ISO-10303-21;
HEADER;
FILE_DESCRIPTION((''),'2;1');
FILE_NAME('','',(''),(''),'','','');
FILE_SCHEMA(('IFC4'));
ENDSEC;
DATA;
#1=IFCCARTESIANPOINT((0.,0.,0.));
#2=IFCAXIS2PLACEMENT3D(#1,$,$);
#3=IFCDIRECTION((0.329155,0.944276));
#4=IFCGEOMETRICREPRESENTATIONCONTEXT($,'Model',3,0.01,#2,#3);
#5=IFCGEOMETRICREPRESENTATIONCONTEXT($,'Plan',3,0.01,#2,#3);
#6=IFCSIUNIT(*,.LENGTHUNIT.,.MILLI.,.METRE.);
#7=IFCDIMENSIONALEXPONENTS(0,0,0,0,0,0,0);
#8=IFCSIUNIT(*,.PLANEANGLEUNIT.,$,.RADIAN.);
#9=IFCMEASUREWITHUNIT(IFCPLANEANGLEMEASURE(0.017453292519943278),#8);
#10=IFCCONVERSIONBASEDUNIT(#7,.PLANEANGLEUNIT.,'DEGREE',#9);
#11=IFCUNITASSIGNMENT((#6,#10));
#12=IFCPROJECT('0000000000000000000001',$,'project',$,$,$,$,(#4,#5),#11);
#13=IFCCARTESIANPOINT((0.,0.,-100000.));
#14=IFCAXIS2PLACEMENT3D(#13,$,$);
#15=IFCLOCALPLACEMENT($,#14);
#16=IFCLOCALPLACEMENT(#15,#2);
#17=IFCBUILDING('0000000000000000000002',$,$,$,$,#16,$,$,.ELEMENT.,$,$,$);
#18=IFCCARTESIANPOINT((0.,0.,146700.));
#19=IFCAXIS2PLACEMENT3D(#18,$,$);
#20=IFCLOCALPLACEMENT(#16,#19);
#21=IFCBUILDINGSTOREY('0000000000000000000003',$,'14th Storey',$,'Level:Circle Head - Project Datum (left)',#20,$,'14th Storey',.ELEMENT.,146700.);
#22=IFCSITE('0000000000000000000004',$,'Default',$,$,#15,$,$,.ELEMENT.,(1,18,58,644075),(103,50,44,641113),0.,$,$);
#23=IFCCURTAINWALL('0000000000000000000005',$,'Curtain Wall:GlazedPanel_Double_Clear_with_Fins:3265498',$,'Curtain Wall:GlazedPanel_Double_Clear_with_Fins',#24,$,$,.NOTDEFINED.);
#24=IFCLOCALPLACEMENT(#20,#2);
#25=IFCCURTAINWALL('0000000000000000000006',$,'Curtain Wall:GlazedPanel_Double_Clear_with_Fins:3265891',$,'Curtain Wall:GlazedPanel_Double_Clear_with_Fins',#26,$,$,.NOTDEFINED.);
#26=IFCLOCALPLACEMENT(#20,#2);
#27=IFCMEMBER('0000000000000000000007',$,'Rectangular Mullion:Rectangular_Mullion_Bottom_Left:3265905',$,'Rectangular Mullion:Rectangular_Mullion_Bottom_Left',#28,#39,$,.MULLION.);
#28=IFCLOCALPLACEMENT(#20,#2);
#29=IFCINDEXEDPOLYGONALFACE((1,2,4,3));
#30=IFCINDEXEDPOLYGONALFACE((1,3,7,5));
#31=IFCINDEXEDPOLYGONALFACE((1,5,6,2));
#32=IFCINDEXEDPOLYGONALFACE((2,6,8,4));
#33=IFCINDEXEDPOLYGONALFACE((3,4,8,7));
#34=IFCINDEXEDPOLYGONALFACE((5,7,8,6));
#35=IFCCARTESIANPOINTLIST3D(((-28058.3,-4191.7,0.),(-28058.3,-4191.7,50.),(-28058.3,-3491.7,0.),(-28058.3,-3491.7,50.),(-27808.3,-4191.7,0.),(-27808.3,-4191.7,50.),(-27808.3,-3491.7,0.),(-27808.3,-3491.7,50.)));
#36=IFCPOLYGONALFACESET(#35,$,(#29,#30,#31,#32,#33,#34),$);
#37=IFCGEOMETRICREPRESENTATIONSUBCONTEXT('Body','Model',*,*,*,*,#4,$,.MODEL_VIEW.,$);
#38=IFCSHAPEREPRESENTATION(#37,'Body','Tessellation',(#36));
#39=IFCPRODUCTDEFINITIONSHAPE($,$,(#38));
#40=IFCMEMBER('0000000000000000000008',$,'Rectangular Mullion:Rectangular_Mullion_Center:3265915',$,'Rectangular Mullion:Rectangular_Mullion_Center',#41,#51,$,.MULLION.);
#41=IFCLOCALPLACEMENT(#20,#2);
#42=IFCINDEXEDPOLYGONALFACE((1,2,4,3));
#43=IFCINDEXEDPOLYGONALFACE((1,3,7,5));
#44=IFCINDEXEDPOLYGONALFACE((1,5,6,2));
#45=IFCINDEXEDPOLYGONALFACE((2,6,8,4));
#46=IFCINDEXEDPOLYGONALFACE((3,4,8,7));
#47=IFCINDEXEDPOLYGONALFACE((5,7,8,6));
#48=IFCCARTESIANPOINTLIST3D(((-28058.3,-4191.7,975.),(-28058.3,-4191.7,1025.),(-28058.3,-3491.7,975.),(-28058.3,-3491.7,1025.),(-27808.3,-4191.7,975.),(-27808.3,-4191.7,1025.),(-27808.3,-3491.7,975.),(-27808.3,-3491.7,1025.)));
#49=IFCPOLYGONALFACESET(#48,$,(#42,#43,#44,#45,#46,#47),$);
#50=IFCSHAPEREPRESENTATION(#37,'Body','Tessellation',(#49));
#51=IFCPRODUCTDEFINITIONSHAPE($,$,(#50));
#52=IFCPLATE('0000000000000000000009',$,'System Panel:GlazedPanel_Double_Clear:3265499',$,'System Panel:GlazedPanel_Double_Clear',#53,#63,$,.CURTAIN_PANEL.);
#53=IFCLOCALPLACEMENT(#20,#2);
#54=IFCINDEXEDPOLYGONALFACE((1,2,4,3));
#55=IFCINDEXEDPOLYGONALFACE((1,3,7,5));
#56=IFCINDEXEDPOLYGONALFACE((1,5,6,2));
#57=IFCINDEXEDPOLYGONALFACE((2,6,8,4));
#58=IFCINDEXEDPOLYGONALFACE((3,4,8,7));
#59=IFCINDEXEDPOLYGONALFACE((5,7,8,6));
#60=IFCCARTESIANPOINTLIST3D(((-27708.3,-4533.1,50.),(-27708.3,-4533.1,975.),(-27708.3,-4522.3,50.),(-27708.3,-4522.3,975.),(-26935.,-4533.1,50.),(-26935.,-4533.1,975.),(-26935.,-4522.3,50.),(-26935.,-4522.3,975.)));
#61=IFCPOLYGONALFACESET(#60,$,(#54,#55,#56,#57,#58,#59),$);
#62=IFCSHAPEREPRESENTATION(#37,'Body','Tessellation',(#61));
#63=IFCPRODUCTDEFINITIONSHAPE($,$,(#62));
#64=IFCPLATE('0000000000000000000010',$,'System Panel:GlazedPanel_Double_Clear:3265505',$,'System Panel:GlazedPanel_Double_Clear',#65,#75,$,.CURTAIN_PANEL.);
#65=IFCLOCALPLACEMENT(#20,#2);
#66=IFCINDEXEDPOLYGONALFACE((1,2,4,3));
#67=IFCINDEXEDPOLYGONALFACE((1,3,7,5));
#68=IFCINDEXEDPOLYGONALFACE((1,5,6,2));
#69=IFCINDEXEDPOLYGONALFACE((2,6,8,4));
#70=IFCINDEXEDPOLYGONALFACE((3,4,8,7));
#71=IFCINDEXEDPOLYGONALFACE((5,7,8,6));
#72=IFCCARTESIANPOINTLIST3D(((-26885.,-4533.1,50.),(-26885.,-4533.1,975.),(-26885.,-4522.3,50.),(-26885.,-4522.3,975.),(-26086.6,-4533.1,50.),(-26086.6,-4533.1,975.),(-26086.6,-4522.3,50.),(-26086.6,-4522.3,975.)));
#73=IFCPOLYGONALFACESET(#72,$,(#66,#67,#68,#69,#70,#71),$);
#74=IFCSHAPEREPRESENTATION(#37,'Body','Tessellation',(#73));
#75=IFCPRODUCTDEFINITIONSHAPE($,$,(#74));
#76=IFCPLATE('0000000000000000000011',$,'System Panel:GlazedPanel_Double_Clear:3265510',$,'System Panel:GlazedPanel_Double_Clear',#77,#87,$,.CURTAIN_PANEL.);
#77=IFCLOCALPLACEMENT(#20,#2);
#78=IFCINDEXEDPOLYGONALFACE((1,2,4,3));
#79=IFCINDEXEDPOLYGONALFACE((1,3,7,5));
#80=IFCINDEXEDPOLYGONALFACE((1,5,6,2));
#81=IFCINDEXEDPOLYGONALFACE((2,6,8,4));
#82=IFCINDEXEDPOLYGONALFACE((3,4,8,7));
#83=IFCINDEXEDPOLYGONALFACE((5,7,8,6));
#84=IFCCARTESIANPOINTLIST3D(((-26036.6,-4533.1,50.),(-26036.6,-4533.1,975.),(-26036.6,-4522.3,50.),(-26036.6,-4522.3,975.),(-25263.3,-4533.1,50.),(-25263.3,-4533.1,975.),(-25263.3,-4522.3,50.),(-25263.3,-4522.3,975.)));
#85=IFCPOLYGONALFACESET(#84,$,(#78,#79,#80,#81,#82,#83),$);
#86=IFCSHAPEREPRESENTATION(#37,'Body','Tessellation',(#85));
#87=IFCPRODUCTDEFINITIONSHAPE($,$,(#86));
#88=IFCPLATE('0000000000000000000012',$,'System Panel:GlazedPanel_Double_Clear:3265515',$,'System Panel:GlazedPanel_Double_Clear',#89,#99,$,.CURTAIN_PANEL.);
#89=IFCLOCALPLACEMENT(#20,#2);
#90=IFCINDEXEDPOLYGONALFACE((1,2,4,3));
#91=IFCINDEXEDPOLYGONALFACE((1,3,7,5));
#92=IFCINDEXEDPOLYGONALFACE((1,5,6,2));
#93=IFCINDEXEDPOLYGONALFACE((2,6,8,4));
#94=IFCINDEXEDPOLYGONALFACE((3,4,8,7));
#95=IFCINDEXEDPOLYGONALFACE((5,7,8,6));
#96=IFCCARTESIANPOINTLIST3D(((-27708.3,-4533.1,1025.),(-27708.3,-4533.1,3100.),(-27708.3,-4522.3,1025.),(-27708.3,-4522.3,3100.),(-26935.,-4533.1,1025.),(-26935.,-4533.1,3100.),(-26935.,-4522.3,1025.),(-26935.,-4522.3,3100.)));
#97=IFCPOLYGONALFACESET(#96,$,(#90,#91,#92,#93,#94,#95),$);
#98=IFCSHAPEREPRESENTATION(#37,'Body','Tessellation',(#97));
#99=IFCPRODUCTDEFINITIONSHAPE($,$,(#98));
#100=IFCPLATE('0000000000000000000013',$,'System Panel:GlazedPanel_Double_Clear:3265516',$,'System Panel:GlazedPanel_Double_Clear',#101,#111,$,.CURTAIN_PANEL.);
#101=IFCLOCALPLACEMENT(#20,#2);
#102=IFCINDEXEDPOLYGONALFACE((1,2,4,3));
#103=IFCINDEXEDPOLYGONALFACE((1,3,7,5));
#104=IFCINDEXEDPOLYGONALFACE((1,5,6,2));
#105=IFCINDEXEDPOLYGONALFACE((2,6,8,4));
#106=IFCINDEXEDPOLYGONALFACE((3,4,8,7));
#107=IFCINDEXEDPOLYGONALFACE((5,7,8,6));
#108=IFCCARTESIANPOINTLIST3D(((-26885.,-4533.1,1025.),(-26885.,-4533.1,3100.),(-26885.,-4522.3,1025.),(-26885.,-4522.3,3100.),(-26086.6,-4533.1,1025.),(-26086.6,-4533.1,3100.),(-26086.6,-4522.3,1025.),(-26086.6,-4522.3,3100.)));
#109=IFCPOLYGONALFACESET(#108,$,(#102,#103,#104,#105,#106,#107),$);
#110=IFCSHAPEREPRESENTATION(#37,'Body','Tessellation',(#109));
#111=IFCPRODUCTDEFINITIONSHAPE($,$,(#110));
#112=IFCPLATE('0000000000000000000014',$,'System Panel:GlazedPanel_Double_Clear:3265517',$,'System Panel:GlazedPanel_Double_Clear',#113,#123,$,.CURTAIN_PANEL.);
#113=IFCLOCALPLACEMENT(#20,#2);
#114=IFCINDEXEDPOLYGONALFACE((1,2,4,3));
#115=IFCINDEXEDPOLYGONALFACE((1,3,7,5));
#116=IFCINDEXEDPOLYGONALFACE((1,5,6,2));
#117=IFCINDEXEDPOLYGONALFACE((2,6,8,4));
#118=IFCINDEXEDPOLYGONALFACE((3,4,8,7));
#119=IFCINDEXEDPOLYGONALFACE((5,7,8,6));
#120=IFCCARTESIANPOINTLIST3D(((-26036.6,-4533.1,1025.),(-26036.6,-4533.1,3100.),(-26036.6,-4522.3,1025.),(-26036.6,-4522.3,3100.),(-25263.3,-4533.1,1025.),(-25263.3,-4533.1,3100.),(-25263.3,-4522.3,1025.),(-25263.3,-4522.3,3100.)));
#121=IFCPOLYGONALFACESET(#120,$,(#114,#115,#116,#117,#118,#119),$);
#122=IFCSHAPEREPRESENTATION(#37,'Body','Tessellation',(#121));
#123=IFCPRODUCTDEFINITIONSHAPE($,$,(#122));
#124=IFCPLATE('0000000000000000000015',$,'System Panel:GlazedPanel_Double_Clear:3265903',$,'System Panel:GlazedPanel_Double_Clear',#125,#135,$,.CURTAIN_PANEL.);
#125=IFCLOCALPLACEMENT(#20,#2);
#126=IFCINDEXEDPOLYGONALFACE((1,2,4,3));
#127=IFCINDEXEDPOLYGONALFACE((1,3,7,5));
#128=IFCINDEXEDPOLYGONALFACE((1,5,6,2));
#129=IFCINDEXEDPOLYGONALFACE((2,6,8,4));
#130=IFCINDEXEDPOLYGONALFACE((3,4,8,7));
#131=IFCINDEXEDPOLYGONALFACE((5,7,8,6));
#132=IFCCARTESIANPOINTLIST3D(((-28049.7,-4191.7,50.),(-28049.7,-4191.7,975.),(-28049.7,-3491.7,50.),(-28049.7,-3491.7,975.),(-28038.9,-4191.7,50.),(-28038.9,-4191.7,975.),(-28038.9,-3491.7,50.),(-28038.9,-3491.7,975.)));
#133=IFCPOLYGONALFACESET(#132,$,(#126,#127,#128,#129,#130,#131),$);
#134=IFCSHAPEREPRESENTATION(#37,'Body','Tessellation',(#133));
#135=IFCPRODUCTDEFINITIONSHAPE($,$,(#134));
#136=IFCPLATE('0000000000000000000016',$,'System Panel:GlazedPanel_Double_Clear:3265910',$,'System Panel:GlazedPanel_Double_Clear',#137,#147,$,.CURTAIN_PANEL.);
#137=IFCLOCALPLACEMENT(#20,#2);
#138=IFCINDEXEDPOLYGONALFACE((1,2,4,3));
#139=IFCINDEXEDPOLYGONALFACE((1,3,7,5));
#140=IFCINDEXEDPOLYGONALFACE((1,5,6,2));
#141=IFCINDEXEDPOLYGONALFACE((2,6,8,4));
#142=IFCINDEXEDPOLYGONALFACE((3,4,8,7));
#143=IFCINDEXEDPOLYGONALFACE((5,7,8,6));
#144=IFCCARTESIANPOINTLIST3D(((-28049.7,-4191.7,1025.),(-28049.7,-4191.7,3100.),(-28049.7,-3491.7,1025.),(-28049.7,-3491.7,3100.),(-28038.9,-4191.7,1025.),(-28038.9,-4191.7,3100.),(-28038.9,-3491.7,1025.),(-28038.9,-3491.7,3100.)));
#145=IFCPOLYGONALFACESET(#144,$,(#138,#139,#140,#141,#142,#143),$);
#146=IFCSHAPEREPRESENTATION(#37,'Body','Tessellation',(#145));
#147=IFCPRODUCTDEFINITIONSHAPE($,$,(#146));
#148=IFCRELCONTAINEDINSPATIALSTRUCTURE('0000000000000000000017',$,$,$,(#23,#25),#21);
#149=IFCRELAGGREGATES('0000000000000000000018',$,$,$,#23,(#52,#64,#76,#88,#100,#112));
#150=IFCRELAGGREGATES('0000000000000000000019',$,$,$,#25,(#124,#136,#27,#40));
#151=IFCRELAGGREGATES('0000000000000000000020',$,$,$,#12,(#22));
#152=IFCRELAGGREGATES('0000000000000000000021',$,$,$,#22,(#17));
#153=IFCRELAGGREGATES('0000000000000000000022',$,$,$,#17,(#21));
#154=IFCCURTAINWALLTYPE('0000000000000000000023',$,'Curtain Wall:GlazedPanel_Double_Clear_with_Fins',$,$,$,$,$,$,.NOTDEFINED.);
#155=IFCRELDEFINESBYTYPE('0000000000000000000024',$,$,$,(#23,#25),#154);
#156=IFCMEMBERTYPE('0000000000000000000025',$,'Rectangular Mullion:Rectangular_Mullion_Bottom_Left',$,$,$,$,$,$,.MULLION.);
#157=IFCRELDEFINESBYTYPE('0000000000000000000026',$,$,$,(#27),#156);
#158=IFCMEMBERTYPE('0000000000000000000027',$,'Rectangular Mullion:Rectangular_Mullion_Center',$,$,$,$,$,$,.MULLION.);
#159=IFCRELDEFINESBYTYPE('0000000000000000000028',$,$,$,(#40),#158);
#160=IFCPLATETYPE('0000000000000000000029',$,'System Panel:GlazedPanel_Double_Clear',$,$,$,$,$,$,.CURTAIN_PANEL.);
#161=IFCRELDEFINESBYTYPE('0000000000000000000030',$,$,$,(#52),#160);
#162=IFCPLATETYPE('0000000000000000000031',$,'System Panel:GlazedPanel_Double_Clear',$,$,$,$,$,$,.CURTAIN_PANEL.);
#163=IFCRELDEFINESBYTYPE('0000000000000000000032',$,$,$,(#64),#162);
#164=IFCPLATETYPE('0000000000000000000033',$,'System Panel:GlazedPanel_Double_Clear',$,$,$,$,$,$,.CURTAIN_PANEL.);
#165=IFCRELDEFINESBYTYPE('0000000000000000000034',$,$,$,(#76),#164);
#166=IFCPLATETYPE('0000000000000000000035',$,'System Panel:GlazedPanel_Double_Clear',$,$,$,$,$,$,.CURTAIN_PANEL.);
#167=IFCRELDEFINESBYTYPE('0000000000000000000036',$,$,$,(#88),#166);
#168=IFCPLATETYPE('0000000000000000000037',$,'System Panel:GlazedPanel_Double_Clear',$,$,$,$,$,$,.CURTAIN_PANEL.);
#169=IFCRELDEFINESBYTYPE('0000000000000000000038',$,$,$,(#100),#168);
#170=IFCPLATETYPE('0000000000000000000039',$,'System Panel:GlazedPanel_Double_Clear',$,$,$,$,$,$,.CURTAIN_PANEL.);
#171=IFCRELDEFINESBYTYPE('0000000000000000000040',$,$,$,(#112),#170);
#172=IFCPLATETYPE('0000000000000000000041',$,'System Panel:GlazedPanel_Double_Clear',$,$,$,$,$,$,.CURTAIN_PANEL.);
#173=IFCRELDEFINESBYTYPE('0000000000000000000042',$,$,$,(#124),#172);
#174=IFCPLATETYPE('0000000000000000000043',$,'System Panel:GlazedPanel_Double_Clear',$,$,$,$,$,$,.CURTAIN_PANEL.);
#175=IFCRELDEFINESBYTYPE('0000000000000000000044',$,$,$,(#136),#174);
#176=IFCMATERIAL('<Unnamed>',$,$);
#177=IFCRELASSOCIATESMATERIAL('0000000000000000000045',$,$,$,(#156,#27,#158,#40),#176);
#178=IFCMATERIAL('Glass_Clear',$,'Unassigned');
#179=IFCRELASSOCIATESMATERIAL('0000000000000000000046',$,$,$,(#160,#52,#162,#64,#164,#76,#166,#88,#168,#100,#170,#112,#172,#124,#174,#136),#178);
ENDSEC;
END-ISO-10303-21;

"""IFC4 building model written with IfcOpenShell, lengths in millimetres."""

from ifc_helpers import new_model, entity, si_unit, converted_unit, direction, frame, origin, place, context, subcontext, project, spatial, indexed_curve, outline, extrude, source, transform, mapped, material, type_object, type_shapes, element, aggregate, save


model = new_model("IFC4")

# Units and contexts
model_context = context("Model", 3, precision=0.01, world=origin(), true_north=direction((0.329155, 0.944276)))
plan_context = context("Plan", 3, precision=0.01, world=origin(), true_north=direction((0.329155, 0.944276)))
body_context = subcontext(model_context, "Body", "Model", "MODEL_VIEW")
ifc_project = project(units=[si_unit("LENGTHUNIT", "METRE", prefix="MILLI"), converted_unit("PLANEANGLEUNIT", "DEGREE", entity("IfcPlaneAngleMeasure", 0.017453292519943278), si_unit("PLANEANGLEUNIT", "RADIAN"), dimensions=[0, 0, 0, 0, 0, 0, 0])], contexts=[model_context, plan_context])

# Site, building, storey
site_placement = place(None, frame((0.0, 0.0, -100000.0)))
site = spatial("IfcSite", under=ifc_project, at=site_placement, Name="Default", CompositionType="ELEMENT", RefLatitude=(1, 18, 58, 644075), RefLongitude=(103, 50, 44, 641113), RefElevation=0.0)
building_placement = place(site_placement, origin())
building = spatial("IfcBuilding", under=site, at=building_placement, CompositionType="ELEMENT")
storey_placement = place(building_placement, frame((0.0, 0.0, 146700.0)))
storey = spatial("IfcBuildingStorey", under=building, at=storey_placement, Name="14th Storey", ObjectType="Level:Circle Head - Project Datum (left)", LongName="14th Storey", CompositionType="ELEMENT", Elevation=146700.0)

# Curtain walls
curtain_wall_type = type_object("IfcCurtainWallType", Name="Curtain Wall:GlazedPanel_Double_Clear_with_Fins", PredefinedType="NOTDEFINED")
curtain_wall_1_placement = place(storey_placement, frame((0.0, 0.0, -146700.0)))
curtain_wall_1 = element("IfcCurtainWall", 1, at=curtain_wall_1_placement, inside=storey, type_object=curtain_wall_type, Name="Curtain Wall:GlazedPanel_Double_Clear_with_Fins:3265498", ObjectType="Curtain Wall:GlazedPanel_Double_Clear_with_Fins", PredefinedType="NOTDEFINED")
ifc_material_1 = material(Name="<Unnamed>")
curtain_wall_2_placement = place(storey_placement, frame((0.0, 0.0, -146700.0)))
curtain_wall_2 = element("IfcCurtainWall", 2, at=curtain_wall_2_placement, inside=storey, type_object=curtain_wall_type, Name="Curtain Wall:GlazedPanel_Double_Clear_with_Fins:3265891", ObjectType="Curtain Wall:GlazedPanel_Double_Clear_with_Fins", PredefinedType="NOTDEFINED")

# Members
member_type_1 = type_object("IfcMemberType", Name="Rectangular Mullion:Rectangular_Mullion_Bottom_Left", PredefinedType="MULLION", material=ifc_material_1)
shared_shape_1 = source(origin(), body_context, "Body", "SweptSolid", [
    extrude(outline(indexed_curve([(-25.0, -125.0), (25.0, -125.0), (25.0, 125.0), (-25.0, 125.0), (-25.0, -125.0)], self_intersect=False)), frame((-25.0, 0.0, -700.0), z_axis=(0.0, 0.0, 1.0), x_axis=(-1.0, 0.0, 0.0)), (0.0, 0.0, 1.0), 700.0),
])
type_shapes(member_type_1, [shared_shape_1])
member_1_placement = place(curtain_wall_2_placement, frame((-27933.3, -3491.7, 146700.0), z_axis=(0.0, 1.0, 0.0), x_axis=(0.0, 0.0, -1.0)))
member_1 = element("IfcMember", 3, at=member_1_placement, type_object=member_type_1, material=ifc_material_1, Name="Rectangular Mullion:Rectangular_Mullion_Bottom_Left:3265905", ObjectType="Rectangular Mullion:Rectangular_Mullion_Bottom_Left", PredefinedType="MULLION", context=body_context, shape_type="MappedRepresentation", body=[
    mapped(shared_shape_1, transform((0.0, 0.0, 0.0), scale=1.0)),
])
member_type_2 = type_object("IfcMemberType", Name="Rectangular Mullion:Rectangular_Mullion_Center", PredefinedType="MULLION", material=ifc_material_1)
shared_shape_2 = source(origin(), body_context, "Body", "SweptSolid", [
    extrude(outline(indexed_curve([(-25.0, -125.0), (25.0, -125.0), (25.0, 125.0), (-25.0, 125.0), (-25.0, -125.0)], self_intersect=False)), frame((0.0, 0.0, -700.0), z_axis=(0.0, 0.0, 1.0), x_axis=(-1.0, 0.0, 0.0)), (0.0, 0.0, 1.0), 700.0),
])
type_shapes(member_type_2, [shared_shape_2])
member_2_placement = place(curtain_wall_2_placement, frame((-27933.3, -4191.7, 147700.0), z_axis=(0.0, -1.0, 0.0), x_axis=(0.0, 0.0, 1.0)))
member_2 = element("IfcMember", 4, at=member_2_placement, type_object=member_type_2, material=ifc_material_1, Name="Rectangular Mullion:Rectangular_Mullion_Center:3265915", ObjectType="Rectangular Mullion:Rectangular_Mullion_Center", PredefinedType="MULLION", context=body_context, shape_type="MappedRepresentation", body=[
    mapped(shared_shape_2, transform((0.0, 0.0, 0.0), scale=1.0)),
])

# Plates
ifc_material_2 = material(Name="Glass_Clear", Category="Unassigned")
plate_type_1 = type_object("IfcPlateType", Name="System Panel:GlazedPanel_Double_Clear", PredefinedType="CURTAIN_PANEL", material=ifc_material_2)
shared_shape_3 = source(origin(), body_context, "Body", "SweptSolid", [
    extrude(outline(indexed_curve([(-5.4, -386.7), (5.4, -386.7), (5.4, 386.7), (-5.4, 386.7), (-5.4, -386.7)], self_intersect=False)), frame((386.7, 5.4, 0.0), z_axis=(0.0, 0.0, 1.0), x_axis=(0.0, 1.0, 0.0)), (0.0, 0.0, 1.0), 925.0),
])
type_shapes(plate_type_1, [shared_shape_3])
plate_1_placement = place(curtain_wall_1_placement, frame((-27708.3, -4533.1, 146750.0)))
plate_1 = element("IfcPlate", 5, at=plate_1_placement, type_object=plate_type_1, material=ifc_material_2, Name="System Panel:GlazedPanel_Double_Clear:3265499", ObjectType="System Panel:GlazedPanel_Double_Clear", PredefinedType="CURTAIN_PANEL", context=body_context, shape_type="MappedRepresentation", body=[
    mapped(shared_shape_3, transform((0.0, 0.0, 0.0), scale=1.0)),
])
plate_type_2 = type_object("IfcPlateType", Name="System Panel:GlazedPanel_Double_Clear", PredefinedType="CURTAIN_PANEL", material=ifc_material_2)
shared_shape_4 = source(origin(), body_context, "Body", "SweptSolid", [
    extrude(outline(indexed_curve([(-5.4, -399.2), (5.4, -399.2), (5.4, 399.2), (-5.4, 399.2), (-5.4, -399.2)], self_intersect=False)), frame((399.2, 5.4, 0.0), z_axis=(0.0, 0.0, 1.0), x_axis=(0.0, 1.0, 0.0)), (0.0, 0.0, 1.0), 925.0),
])
type_shapes(plate_type_2, [shared_shape_4])
plate_2_placement = place(curtain_wall_1_placement, frame((-26885.0, -4533.1, 146750.0)))
plate_2 = element("IfcPlate", 6, at=plate_2_placement, type_object=plate_type_2, material=ifc_material_2, Name="System Panel:GlazedPanel_Double_Clear:3265505", ObjectType="System Panel:GlazedPanel_Double_Clear", PredefinedType="CURTAIN_PANEL", context=body_context, shape_type="MappedRepresentation", body=[
    mapped(shared_shape_4, transform((0.0, 0.0, 0.0), scale=1.0)),
])
plate_type_3 = type_object("IfcPlateType", Name="System Panel:GlazedPanel_Double_Clear", PredefinedType="CURTAIN_PANEL", material=ifc_material_2)
shared_shape_5 = source(origin(), body_context, "Body", "SweptSolid", [
    extrude(outline(indexed_curve([(-5.4, -386.6), (5.4, -386.6), (5.4, 386.6), (-5.4, 386.6), (-5.4, -386.6)], self_intersect=False)), frame((386.6, 5.4, 0.0), z_axis=(0.0, 0.0, 1.0), x_axis=(0.0, 1.0, 0.0)), (0.0, 0.0, 1.0), 925.0),
])
type_shapes(plate_type_3, [shared_shape_5])
plate_3_placement = place(curtain_wall_1_placement, frame((-26036.6, -4533.1, 146750.0)))
plate_3 = element("IfcPlate", 7, at=plate_3_placement, type_object=plate_type_3, material=ifc_material_2, Name="System Panel:GlazedPanel_Double_Clear:3265510", ObjectType="System Panel:GlazedPanel_Double_Clear", PredefinedType="CURTAIN_PANEL", context=body_context, shape_type="MappedRepresentation", body=[
    mapped(shared_shape_5, transform((0.0, 0.0, 0.0), scale=1.0)),
])
plate_type_4 = type_object("IfcPlateType", Name="System Panel:GlazedPanel_Double_Clear", PredefinedType="CURTAIN_PANEL", material=ifc_material_2)
shared_shape_6 = source(origin(), body_context, "Body", "SweptSolid", [
    extrude(outline(indexed_curve([(-5.4, -386.7), (5.4, -386.7), (5.4, 386.7), (-5.4, 386.7), (-5.4, -386.7)], self_intersect=False)), frame((386.7, 5.4, 0.0), z_axis=(0.0, 0.0, 1.0), x_axis=(0.0, 1.0, 0.0)), (0.0, 0.0, 1.0), 2075.0),
])
type_shapes(plate_type_4, [shared_shape_6])
plate_4_placement = place(curtain_wall_1_placement, frame((-27708.3, -4533.1, 147725.0)))
plate_4 = element("IfcPlate", 8, at=plate_4_placement, type_object=plate_type_4, material=ifc_material_2, Name="System Panel:GlazedPanel_Double_Clear:3265515", ObjectType="System Panel:GlazedPanel_Double_Clear", PredefinedType="CURTAIN_PANEL", context=body_context, shape_type="MappedRepresentation", body=[
    mapped(shared_shape_6, transform((0.0, 0.0, 0.0), scale=1.0)),
])
plate_type_5 = type_object("IfcPlateType", Name="System Panel:GlazedPanel_Double_Clear", PredefinedType="CURTAIN_PANEL", material=ifc_material_2)
shared_shape_7 = source(origin(), body_context, "Body", "SweptSolid", [
    extrude(outline(indexed_curve([(-5.4, -399.2), (5.4, -399.2), (5.4, 399.2), (-5.4, 399.2), (-5.4, -399.2)], self_intersect=False)), frame((399.2, 5.4, 0.0), z_axis=(0.0, 0.0, 1.0), x_axis=(0.0, 1.0, 0.0)), (0.0, 0.0, 1.0), 2075.0),
])
type_shapes(plate_type_5, [shared_shape_7])
plate_5_placement = place(curtain_wall_1_placement, frame((-26885.0, -4533.1, 147725.0)))
plate_5 = element("IfcPlate", 9, at=plate_5_placement, type_object=plate_type_5, material=ifc_material_2, Name="System Panel:GlazedPanel_Double_Clear:3265516", ObjectType="System Panel:GlazedPanel_Double_Clear", PredefinedType="CURTAIN_PANEL", context=body_context, shape_type="MappedRepresentation", body=[
    mapped(shared_shape_7, transform((0.0, 0.0, 0.0), scale=1.0)),
])
plate_type_6 = type_object("IfcPlateType", Name="System Panel:GlazedPanel_Double_Clear", PredefinedType="CURTAIN_PANEL", material=ifc_material_2)
shared_shape_8 = source(origin(), body_context, "Body", "SweptSolid", [
    extrude(outline(indexed_curve([(-5.4, -386.6), (5.4, -386.6), (5.4, 386.6), (-5.4, 386.6), (-5.4, -386.6)], self_intersect=False)), frame((386.6, 5.4, 0.0), z_axis=(0.0, 0.0, 1.0), x_axis=(0.0, 1.0, 0.0)), (0.0, 0.0, 1.0), 2075.0),
])
type_shapes(plate_type_6, [shared_shape_8])
plate_6_placement = place(curtain_wall_1_placement, frame((-26036.6, -4533.1, 147725.0)))
plate_6 = element("IfcPlate", 10, at=plate_6_placement, type_object=plate_type_6, material=ifc_material_2, Name="System Panel:GlazedPanel_Double_Clear:3265517", ObjectType="System Panel:GlazedPanel_Double_Clear", PredefinedType="CURTAIN_PANEL", context=body_context, shape_type="MappedRepresentation", body=[
    mapped(shared_shape_8, transform((0.0, 0.0, 0.0), scale=1.0)),
])
aggregate(curtain_wall_1, [plate_1, plate_2, plate_3, plate_4, plate_5, plate_6])
plate_type_7 = type_object("IfcPlateType", Name="System Panel:GlazedPanel_Double_Clear", PredefinedType="CURTAIN_PANEL", material=ifc_material_2)
shared_shape_9 = source(origin(), body_context, "Body", "SweptSolid", [
    extrude(outline(indexed_curve([(-5.4, -350.0), (5.4, -350.0), (5.4, 350.0), (-5.4, 350.0), (-5.4, -350.0)], self_intersect=False)), frame((350.0, 5.4, 0.0), z_axis=(0.0, 0.0, 1.0), x_axis=(0.0, 1.0, 0.0)), (0.0, 0.0, 1.0), 925.0),
])
type_shapes(plate_type_7, [shared_shape_9])
plate_7_placement = place(curtain_wall_2_placement, frame((-28049.7, -3491.7, 146750.0), z_axis=(0.0, 0.0, 1.0), x_axis=(0.0, -1.0, 0.0)))
plate_7 = element("IfcPlate", 11, at=plate_7_placement, type_object=plate_type_7, material=ifc_material_2, Name="System Panel:GlazedPanel_Double_Clear:3265903", ObjectType="System Panel:GlazedPanel_Double_Clear", PredefinedType="CURTAIN_PANEL", context=body_context, shape_type="MappedRepresentation", body=[
    mapped(shared_shape_9, transform((0.0, 0.0, 0.0), scale=1.0)),
])
plate_type_8 = type_object("IfcPlateType", Name="System Panel:GlazedPanel_Double_Clear", PredefinedType="CURTAIN_PANEL", material=ifc_material_2)
shared_shape_10 = source(origin(), body_context, "Body", "SweptSolid", [
    extrude(outline(indexed_curve([(-5.4, -350.0), (5.4, -350.0), (5.4, 350.0), (-5.4, 350.0), (-5.4, -350.0)], self_intersect=False)), frame((350.0, 5.4, 0.0), z_axis=(0.0, 0.0, 1.0), x_axis=(0.0, 1.0, 0.0)), (0.0, 0.0, 1.0), 2075.0),
])
type_shapes(plate_type_8, [shared_shape_10])
plate_8_placement = place(curtain_wall_2_placement, frame((-28049.7, -3491.7, 147725.0), z_axis=(0.0, 0.0, 1.0), x_axis=(0.0, -1.0, 0.0)))
plate_8 = element("IfcPlate", 12, at=plate_8_placement, type_object=plate_type_8, material=ifc_material_2, Name="System Panel:GlazedPanel_Double_Clear:3265910", ObjectType="System Panel:GlazedPanel_Double_Clear", PredefinedType="CURTAIN_PANEL", context=body_context, shape_type="MappedRepresentation", body=[
    mapped(shared_shape_10, transform((0.0, 0.0, 0.0), scale=1.0)),
])
aggregate(curtain_wall_2, [plate_7, plate_8, member_1, member_2])

save(model, "model.ifc")
